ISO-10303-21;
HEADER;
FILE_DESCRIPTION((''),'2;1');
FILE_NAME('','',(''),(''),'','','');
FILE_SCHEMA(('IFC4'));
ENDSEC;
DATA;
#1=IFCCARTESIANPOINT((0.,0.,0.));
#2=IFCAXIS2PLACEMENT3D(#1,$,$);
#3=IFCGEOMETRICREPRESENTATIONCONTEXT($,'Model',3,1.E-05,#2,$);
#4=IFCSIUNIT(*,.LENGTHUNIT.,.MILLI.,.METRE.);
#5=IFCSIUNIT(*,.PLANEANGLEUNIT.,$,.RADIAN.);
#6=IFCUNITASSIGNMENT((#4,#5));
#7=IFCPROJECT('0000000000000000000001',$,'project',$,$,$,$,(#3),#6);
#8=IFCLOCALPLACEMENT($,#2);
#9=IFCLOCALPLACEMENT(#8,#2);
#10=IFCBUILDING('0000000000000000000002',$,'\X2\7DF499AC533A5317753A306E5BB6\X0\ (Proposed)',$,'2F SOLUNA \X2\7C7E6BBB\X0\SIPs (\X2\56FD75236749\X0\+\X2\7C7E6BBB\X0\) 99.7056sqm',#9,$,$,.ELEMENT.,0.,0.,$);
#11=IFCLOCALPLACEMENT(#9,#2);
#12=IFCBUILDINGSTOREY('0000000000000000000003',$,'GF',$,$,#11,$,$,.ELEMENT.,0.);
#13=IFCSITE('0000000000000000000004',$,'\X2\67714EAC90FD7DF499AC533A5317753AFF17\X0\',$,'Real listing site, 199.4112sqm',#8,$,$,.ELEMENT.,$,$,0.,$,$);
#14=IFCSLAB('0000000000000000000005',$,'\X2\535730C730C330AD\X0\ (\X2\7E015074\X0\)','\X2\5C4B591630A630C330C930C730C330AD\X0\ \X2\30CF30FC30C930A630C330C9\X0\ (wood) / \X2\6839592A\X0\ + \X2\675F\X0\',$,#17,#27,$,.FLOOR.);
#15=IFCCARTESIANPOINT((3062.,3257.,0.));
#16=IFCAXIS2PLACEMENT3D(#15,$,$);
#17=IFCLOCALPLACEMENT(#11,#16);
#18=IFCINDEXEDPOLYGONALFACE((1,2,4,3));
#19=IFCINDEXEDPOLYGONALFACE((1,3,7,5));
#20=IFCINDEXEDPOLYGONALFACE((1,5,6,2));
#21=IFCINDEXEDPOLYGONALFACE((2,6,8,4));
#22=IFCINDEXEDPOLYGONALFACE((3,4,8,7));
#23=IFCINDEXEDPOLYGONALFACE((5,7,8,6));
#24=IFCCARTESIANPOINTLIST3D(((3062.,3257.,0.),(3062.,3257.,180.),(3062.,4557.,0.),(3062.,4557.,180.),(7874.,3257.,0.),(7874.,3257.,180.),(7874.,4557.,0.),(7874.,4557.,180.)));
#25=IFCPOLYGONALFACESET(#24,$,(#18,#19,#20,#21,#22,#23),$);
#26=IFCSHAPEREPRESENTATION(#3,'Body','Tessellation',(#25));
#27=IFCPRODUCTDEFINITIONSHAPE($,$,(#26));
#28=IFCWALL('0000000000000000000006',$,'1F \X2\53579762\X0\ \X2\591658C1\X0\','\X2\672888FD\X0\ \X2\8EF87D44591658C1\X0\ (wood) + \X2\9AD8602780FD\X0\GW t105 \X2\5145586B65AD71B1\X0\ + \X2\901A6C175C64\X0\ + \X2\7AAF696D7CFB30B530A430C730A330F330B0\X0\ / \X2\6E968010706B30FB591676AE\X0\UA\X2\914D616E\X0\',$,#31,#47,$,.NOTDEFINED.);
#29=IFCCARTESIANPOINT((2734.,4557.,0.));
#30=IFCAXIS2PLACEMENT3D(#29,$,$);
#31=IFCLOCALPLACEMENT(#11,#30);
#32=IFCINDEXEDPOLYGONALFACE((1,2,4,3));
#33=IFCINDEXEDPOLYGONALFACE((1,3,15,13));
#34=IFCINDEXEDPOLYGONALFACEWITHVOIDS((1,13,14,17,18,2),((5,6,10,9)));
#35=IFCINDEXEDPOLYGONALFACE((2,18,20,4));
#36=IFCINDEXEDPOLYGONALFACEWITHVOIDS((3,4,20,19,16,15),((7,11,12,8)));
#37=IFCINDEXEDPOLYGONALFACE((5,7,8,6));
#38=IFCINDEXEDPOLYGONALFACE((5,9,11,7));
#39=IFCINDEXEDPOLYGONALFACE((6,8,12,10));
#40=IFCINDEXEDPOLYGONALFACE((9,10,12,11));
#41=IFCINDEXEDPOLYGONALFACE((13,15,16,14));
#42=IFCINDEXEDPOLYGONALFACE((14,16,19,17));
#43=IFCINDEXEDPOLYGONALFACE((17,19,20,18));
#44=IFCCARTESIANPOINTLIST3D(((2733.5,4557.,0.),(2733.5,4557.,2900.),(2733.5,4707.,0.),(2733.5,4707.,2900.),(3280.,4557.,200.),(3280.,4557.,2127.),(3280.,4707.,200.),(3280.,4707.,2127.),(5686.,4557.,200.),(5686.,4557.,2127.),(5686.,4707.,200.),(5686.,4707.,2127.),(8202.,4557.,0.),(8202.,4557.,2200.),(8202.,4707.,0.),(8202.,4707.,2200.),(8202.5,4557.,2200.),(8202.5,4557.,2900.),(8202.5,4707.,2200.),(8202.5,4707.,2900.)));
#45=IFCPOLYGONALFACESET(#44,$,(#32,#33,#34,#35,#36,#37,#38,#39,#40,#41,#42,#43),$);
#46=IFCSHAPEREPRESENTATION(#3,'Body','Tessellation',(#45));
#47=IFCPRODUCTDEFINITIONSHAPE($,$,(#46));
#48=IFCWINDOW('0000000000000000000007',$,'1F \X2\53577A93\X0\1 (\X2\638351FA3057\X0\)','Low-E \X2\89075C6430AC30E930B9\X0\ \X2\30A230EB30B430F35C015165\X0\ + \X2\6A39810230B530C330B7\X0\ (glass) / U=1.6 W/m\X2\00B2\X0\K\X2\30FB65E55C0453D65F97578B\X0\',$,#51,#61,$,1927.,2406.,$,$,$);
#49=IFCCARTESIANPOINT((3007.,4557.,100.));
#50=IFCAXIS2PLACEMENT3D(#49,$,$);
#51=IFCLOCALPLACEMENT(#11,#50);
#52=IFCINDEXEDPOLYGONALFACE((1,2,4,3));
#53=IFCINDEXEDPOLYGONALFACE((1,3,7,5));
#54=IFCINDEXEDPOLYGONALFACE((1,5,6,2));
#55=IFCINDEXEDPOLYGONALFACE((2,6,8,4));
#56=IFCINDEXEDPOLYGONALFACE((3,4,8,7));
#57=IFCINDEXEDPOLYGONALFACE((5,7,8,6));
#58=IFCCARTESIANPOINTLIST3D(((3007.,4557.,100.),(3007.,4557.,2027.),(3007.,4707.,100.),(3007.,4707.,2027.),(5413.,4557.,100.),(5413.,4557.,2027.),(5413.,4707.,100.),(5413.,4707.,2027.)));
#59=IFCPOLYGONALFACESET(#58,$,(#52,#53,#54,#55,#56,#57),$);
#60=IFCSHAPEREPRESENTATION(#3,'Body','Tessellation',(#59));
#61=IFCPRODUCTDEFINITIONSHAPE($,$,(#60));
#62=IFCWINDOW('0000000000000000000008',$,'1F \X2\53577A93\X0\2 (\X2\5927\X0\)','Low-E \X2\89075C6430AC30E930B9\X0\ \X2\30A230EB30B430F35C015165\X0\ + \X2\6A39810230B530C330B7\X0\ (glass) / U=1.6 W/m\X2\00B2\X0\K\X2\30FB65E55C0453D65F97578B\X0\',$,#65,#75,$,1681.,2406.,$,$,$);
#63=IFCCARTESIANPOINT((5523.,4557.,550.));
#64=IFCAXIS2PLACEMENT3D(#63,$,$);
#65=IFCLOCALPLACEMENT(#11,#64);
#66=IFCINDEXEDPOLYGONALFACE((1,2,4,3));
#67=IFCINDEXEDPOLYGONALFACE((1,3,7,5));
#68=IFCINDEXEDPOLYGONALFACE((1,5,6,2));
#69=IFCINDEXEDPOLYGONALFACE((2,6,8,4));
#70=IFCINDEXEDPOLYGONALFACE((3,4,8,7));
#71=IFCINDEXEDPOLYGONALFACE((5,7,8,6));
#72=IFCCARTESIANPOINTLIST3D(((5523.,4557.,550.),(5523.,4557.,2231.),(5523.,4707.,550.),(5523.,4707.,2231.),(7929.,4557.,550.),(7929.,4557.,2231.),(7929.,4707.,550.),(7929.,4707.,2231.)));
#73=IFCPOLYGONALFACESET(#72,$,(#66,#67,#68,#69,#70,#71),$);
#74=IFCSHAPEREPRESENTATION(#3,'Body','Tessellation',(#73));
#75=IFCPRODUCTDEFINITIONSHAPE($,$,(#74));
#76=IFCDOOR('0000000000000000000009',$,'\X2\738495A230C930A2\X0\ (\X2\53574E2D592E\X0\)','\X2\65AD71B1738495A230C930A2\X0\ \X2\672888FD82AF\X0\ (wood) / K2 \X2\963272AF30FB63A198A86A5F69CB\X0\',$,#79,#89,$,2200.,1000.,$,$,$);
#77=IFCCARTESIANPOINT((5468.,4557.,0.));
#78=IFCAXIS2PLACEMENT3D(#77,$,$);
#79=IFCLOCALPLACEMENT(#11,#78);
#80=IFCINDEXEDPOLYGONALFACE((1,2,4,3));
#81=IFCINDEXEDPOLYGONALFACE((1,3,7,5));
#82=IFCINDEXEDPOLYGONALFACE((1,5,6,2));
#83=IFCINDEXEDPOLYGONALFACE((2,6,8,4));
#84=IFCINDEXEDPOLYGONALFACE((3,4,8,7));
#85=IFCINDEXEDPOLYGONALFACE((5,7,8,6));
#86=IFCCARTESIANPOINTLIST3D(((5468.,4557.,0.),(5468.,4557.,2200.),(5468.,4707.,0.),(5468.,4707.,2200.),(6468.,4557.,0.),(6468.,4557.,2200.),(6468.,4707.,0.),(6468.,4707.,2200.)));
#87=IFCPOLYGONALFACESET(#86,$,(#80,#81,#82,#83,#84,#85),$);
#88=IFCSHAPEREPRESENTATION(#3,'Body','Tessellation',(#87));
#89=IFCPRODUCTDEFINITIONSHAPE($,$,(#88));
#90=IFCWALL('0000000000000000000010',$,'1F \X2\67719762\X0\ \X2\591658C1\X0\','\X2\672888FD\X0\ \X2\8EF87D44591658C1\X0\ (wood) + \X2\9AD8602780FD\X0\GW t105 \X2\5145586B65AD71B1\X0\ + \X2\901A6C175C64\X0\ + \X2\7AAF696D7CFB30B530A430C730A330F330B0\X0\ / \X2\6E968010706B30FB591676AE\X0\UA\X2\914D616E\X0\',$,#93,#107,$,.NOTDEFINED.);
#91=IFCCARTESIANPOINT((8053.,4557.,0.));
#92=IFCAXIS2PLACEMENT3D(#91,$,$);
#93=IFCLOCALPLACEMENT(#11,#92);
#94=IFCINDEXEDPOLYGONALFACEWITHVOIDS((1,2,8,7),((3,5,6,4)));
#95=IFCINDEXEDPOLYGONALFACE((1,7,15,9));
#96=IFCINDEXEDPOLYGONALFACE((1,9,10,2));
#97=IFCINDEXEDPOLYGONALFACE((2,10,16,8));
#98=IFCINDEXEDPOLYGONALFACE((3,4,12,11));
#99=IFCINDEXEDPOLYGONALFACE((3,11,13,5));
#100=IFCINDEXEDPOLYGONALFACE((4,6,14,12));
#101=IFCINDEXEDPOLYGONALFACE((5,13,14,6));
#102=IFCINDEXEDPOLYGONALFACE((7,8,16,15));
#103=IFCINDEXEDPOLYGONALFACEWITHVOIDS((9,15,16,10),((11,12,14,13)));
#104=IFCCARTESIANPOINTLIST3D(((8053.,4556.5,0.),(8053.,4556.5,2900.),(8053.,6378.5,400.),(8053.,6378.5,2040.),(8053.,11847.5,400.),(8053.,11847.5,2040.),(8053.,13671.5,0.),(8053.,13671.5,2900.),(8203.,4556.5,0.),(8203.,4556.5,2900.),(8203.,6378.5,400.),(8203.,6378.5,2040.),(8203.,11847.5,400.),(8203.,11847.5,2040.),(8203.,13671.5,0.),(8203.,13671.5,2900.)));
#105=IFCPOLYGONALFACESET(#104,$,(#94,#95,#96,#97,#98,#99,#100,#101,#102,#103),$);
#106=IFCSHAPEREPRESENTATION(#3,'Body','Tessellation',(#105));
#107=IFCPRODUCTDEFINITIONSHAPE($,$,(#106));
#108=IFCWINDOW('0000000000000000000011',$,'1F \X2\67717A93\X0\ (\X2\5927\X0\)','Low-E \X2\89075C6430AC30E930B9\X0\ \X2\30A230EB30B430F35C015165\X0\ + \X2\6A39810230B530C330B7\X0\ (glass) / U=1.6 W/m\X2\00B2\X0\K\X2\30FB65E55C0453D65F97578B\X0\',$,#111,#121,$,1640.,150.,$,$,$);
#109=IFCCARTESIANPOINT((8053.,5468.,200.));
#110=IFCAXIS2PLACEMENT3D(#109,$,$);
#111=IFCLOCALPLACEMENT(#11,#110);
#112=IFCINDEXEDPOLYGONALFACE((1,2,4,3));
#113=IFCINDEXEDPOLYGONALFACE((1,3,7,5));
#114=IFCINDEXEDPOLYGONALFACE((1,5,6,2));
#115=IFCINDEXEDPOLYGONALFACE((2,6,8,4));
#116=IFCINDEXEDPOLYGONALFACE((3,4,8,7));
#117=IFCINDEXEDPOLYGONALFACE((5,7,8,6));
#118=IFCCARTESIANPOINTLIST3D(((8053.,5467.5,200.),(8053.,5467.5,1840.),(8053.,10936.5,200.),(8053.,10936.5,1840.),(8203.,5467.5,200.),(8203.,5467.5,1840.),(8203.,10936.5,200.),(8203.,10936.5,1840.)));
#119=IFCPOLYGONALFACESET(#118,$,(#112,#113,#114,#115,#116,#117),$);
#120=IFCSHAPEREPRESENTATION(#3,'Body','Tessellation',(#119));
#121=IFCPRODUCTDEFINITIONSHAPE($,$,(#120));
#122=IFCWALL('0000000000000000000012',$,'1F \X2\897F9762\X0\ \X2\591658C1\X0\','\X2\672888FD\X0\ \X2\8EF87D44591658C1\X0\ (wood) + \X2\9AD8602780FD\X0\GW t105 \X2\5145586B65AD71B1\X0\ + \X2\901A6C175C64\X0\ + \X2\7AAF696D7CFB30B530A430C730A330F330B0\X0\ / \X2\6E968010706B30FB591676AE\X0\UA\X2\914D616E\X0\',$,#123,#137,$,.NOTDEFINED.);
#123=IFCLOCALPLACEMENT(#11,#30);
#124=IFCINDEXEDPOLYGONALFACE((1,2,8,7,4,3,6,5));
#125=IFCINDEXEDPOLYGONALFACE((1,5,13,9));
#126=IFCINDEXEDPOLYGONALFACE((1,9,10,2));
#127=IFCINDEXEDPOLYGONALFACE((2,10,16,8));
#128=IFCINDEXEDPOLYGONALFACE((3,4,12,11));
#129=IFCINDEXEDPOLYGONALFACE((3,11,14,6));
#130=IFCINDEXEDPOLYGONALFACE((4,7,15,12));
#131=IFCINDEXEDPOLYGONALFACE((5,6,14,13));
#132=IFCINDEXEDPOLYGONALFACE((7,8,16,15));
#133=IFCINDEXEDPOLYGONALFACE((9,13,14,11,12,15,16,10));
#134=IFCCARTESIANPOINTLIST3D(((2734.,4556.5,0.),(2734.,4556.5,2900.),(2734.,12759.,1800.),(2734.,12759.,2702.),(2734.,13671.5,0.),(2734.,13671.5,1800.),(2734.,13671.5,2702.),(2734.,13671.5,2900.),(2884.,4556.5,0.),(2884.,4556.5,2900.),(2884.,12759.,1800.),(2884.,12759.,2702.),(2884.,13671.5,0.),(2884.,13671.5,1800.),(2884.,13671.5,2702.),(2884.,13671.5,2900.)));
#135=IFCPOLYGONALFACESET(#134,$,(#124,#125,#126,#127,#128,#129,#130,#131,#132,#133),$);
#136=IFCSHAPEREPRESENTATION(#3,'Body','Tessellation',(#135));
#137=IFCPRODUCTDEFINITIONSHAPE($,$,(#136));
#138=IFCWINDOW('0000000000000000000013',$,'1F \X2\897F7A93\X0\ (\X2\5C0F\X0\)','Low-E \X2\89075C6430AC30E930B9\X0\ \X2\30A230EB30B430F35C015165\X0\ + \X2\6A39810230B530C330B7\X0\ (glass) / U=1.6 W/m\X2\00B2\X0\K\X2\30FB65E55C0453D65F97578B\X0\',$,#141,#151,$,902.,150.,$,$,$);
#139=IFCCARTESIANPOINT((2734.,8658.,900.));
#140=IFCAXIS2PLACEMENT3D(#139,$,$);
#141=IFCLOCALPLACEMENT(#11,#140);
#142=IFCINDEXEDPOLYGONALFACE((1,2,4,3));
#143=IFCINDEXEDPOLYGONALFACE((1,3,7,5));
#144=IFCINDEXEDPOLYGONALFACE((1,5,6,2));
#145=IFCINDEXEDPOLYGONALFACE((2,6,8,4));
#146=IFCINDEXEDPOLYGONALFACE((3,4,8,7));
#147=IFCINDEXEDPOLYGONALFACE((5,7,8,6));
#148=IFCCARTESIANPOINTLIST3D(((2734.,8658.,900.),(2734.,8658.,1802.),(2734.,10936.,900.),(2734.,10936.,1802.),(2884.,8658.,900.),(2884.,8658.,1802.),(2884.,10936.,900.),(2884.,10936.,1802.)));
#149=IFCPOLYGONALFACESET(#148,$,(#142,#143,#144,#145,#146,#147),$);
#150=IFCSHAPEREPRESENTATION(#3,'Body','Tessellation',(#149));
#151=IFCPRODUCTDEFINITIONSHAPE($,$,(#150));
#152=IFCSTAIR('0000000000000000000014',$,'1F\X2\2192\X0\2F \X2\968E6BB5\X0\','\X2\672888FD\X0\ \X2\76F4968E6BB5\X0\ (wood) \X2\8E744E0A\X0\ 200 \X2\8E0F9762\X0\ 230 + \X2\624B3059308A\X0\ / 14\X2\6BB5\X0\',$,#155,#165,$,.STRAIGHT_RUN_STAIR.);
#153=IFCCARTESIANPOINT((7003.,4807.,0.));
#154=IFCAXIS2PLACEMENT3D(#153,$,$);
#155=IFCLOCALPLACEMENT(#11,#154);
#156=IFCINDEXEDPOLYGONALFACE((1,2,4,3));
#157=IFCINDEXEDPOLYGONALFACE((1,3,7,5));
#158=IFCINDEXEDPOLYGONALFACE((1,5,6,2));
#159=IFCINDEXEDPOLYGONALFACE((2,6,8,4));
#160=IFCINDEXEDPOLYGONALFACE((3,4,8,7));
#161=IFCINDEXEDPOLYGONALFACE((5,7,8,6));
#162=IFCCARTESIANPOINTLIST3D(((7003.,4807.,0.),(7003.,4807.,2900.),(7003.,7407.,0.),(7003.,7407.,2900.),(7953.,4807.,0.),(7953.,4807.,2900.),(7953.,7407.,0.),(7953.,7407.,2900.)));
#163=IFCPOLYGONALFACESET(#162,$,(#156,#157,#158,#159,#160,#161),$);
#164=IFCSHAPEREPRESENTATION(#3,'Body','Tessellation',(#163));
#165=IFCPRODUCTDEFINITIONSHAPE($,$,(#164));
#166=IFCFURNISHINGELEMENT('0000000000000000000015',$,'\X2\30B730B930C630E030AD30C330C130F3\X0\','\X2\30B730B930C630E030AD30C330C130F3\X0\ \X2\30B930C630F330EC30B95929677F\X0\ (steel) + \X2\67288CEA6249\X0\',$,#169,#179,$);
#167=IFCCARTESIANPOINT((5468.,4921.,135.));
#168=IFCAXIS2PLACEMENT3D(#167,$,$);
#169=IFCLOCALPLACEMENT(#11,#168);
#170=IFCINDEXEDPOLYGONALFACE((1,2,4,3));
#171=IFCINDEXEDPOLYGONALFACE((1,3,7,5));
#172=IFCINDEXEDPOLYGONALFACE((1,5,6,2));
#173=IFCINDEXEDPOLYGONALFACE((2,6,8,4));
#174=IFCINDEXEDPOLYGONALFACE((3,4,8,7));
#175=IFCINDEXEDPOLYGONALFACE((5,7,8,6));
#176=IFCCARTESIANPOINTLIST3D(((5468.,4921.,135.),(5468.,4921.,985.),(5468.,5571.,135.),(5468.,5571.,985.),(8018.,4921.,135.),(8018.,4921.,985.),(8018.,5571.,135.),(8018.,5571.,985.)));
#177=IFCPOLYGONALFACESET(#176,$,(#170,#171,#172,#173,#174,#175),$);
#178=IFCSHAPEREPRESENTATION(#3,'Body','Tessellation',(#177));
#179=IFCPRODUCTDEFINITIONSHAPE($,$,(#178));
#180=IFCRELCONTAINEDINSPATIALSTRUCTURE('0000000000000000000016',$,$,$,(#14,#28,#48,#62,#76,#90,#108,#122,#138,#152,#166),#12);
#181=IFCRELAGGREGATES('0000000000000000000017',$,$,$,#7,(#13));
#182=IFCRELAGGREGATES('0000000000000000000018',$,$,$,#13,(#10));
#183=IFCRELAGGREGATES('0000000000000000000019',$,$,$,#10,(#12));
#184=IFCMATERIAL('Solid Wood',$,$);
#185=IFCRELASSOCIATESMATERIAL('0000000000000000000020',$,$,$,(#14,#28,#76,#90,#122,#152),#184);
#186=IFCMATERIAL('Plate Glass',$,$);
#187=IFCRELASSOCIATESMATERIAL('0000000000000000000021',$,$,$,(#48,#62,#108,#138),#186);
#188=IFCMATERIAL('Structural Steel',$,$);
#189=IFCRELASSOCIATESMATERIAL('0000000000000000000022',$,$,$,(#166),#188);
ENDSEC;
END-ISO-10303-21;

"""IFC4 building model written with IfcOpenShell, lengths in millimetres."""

from ifc_helpers import new_model, si_unit, frame, frame_2d, origin, place, context, project, spatial, rectangle, extrude, material, element, fill, save


model = new_model("IFC4")

# Units and contexts
model_context = context("Model", 3, precision=1e-05, world=origin())
ifc_project = project(units=[si_unit("LENGTHUNIT", "METRE", prefix="MILLI"), si_unit("PLANEANGLEUNIT", "RADIAN")], contexts=[model_context])

# Site, building, storey
site_placement = place(None, origin())
site = spatial("IfcSite", under=ifc_project, at=site_placement, Name="東京都練馬区北町７", ObjectType="Real listing site, 199.4112sqm", CompositionType="ELEMENT", RefElevation=0.0)
building_placement = place(site_placement, origin())
building = spatial("IfcBuilding", under=site, at=building_placement, Name="練馬区北町の家 (Proposed)", ObjectType="2F SOLUNA 籾殻SIPs (国産杉+籾殻) 99.7056sqm", CompositionType="ELEMENT", ElevationOfRefHeight=0.0, ElevationOfTerrain=0.0)
storey_placement = place(building_placement, origin())
storey = spatial("IfcBuildingStorey", under=building, at=storey_placement, Name="GF", CompositionType="ELEMENT", Elevation=0.0)

# Slab
ifc_material_1 = material(Name="Solid Wood")
slab_1_placement = place(storey_placement, frame((3062.0, 3257.0, 0.0)))
element("IfcSlab", 1, at=slab_1_placement, inside=storey, material=ifc_material_1, Name="南デッキ (縁側)", Description="屋外ウッドデッキ ハードウッド (wood) / 根太 + 束", PredefinedType="FLOOR", context=model_context, shape_type="SweptSolid", body=[
    extrude(rectangle(XDim=4812.0, YDim=1300.0, at=frame_2d((2406.0, 650.0))), frame((3062.0, 3257.0, 0.0)), (0.0, 0.0, 1.0), 180.0),
])

# Wall, openings, windows, door
wall_1_placement = place(storey_placement, frame((2734.0, 4557.0, 0.0)))
wall_1 = element("IfcWall", 2, at=wall_1_placement, inside=storey, material=ifc_material_1, Name="1F 南面 外壁", Description="木製 軸組外壁 (wood) + 高性能GW t105 充填断熱 + 通気層 + 窯業系サイディング / 準耐火・外皮UA配慮", PredefinedType="NOTDEFINED", context=model_context, shape_type="SweptSolid", body=[
    extrude(rectangle(XDim=5469.0, YDim=150.0, at=frame_2d((2734.0, 75.0))), frame((2734.0, 4557.0, 0.0)), (0.0, 0.0, 1.0), 2900.0),
])
opening_1_placement = place(storey_placement, frame((3007.0, 4557.0, 100.0)))
opening_1 = element("IfcOpeningElement", 3, at=opening_1_placement, cuts=wall_1, PredefinedType="NOTDEFINED", context=model_context, shape_type="SweptSolid", body=[
    extrude(rectangle(XDim=2406.0, YDim=150.0, at=frame_2d((1203.0, 75.0))), frame((3007.0, 4557.0, 100.0)), (0.0, 0.0, 1.0), 1927.0),
])
opening_2_placement = place(storey_placement, frame((5523.0, 4557.0, 550.0)))
opening_2 = element("IfcOpeningElement", 4, at=opening_2_placement, cuts=wall_1, PredefinedType="NOTDEFINED", context=model_context, shape_type="SweptSolid", body=[
    extrude(rectangle(XDim=2406.0, YDim=150.0, at=frame_2d((1203.0, 75.0))), frame((5523.0, 4557.0, 550.0)), (0.0, 0.0, 1.0), 1681.0),
])
opening_3_placement = place(storey_placement, frame((5468.0, 4557.0, 0.0)))
opening_3 = element("IfcOpeningElement", 5, at=opening_3_placement, cuts=wall_1, PredefinedType="NOTDEFINED", context=model_context, shape_type="SweptSolid", body=[
    extrude(rectangle(XDim=1000.0, YDim=150.0, at=frame_2d((500.0, 75.0))), frame((5468.0, 4557.0, 0.0)), (0.0, 0.0, 1.0), 2200.0),
])
ifc_material_2 = material(Name="Plate Glass")
window_1_placement = place(storey_placement, frame((3007.0, 4557.0, 100.0)))
window_1 = element("IfcWindow", 6, at=window_1_placement, inside=storey, material=ifc_material_2, Name="1F 南窓1 (掃出し)", Description="Low-E 複層ガラス アルゴン封入 + 樹脂サッシ (glass) / U=1.6 W/m²K・日射取得型", OverallHeight=1927.0, OverallWidth=2406.0, context=model_context, shape_type="SweptSolid", body=[
    extrude(rectangle(XDim=2406.0, YDim=150.0, at=frame_2d((1203.0, 75.0))), frame((3007.0, 4557.0, 100.0)), (0.0, 0.0, 1.0), 1927.0),
])
fill(opening_1, window_1)
window_2_placement = place(storey_placement, frame((5523.0, 4557.0, 550.0)))
window_2 = element("IfcWindow", 7, at=window_2_placement, inside=storey, material=ifc_material_2, Name="1F 南窓2 (大)", Description="Low-E 複層ガラス アルゴン封入 + 樹脂サッシ (glass) / U=1.6 W/m²K・日射取得型", OverallHeight=1681.0, OverallWidth=2406.0, context=model_context, shape_type="SweptSolid", body=[
    extrude(rectangle(XDim=2406.0, YDim=150.0, at=frame_2d((1203.0, 75.0))), frame((5523.0, 4557.0, 550.0)), (0.0, 0.0, 1.0), 1681.0),
])
fill(opening_2, window_2)
door_placement = place(storey_placement, frame((5468.0, 4557.0, 0.0)))
door = element("IfcDoor", 8, at=door_placement, inside=storey, material=ifc_material_1, Name="玄関ドア (南中央)", Description="断熱玄関ドア 木製芯 (wood) / K2 防犯・採風機構", OverallHeight=2200.0, OverallWidth=1000.0, context=model_context, shape_type="SweptSolid", body=[
    extrude(rectangle(XDim=1000.0, YDim=150.0, at=frame_2d((500.0, 75.0))), frame((5468.0, 4557.0, 0.0)), (0.0, 0.0, 1.0), 2200.0),
])
fill(opening_3, door)

# Walls, openings, windows
wall_2_placement = place(storey_placement, frame((8053.0, 4557.0, 0.0)))
wall_2 = element("IfcWall", 9, at=wall_2_placement, inside=storey, material=ifc_material_1, Name="1F 東面 外壁", Description="木製 軸組外壁 (wood) + 高性能GW t105 充填断熱 + 通気層 + 窯業系サイディング / 準耐火・外皮UA配慮", PredefinedType="NOTDEFINED", context=model_context, shape_type="SweptSolid", body=[
    extrude(rectangle(XDim=150.0, YDim=9115.0, at=frame_2d((75.0, 4557.0))), frame((8053.0, 4557.0, 0.0)), (0.0, 0.0, 1.0), 2900.0),
])
opening_4_placement = place(storey_placement, frame((8053.0, 5468.0, 200.0)))
opening_4 = element("IfcOpeningElement", 10, at=opening_4_placement, cuts=wall_2, PredefinedType="NOTDEFINED", context=model_context, shape_type="SweptSolid", body=[
    extrude(rectangle(XDim=150.0, YDim=5469.0, at=frame_2d((75.0, 2734.0))), frame((8053.0, 5468.0, 200.0)), (0.0, 0.0, 1.0), 1640.0),
])
window_3_placement = place(storey_placement, frame((8053.0, 5468.0, 200.0)))
window_3 = element("IfcWindow", 11, at=window_3_placement, inside=storey, material=ifc_material_2, Name="1F 東窓 (大)", Description="Low-E 複層ガラス アルゴン封入 + 樹脂サッシ (glass) / U=1.6 W/m²K・日射取得型", OverallHeight=1640.0, OverallWidth=150.0, context=model_context, shape_type="SweptSolid", body=[
    extrude(rectangle(XDim=150.0, YDim=5469.0, at=frame_2d((75.0, 2734.0))), frame((8053.0, 5468.0, 200.0)), (0.0, 0.0, 1.0), 1640.0),
])
fill(opening_4, window_3)
wall_3_placement = place(storey_placement, frame((2734.0, 4557.0, 0.0)))
wall_3 = element("IfcWall", 12, at=wall_3_placement, inside=storey, material=ifc_material_1, Name="1F 西面 外壁", Description="木製 軸組外壁 (wood) + 高性能GW t105 充填断熱 + 通気層 + 窯業系サイディング / 準耐火・外皮UA配慮", PredefinedType="NOTDEFINED", context=model_context, shape_type="SweptSolid", body=[
    extrude(rectangle(XDim=150.0, YDim=9115.0, at=frame_2d((75.0, 4557.0))), frame((2734.0, 4557.0, 0.0)), (0.0, 0.0, 1.0), 2900.0),
])
opening_5_placement = place(storey_placement, frame((2734.0, 8658.0, 900.0)))
opening_5 = element("IfcOpeningElement", 13, at=opening_5_placement, cuts=wall_3, PredefinedType="NOTDEFINED", context=model_context, shape_type="SweptSolid", body=[
    extrude(rectangle(XDim=150.0, YDim=2278.0, at=frame_2d((75.0, 1139.0))), frame((2734.0, 8658.0, 900.0)), (0.0, 0.0, 1.0), 902.0),
])
window_4_placement = place(storey_placement, frame((2734.0, 8658.0, 900.0)))
window_4 = element("IfcWindow", 14, at=window_4_placement, inside=storey, material=ifc_material_2, Name="1F 西窓 (小)", Description="Low-E 複層ガラス アルゴン封入 + 樹脂サッシ (glass) / U=1.6 W/m²K・日射取得型", OverallHeight=902.0, OverallWidth=150.0, context=model_context, shape_type="SweptSolid", body=[
    extrude(rectangle(XDim=150.0, YDim=2278.0, at=frame_2d((75.0, 1139.0))), frame((2734.0, 8658.0, 900.0)), (0.0, 0.0, 1.0), 902.0),
])
fill(opening_5, window_4)

# Stair
stair_placement = place(storey_placement, frame((7003.0, 4807.0, 0.0)))
element("IfcStair", 15, at=stair_placement, inside=storey, material=ifc_material_1, Name="1F→2F 階段", Description="木製 直階段 (wood) 蹴上 200 踏面 230 + 手すり / 14段", PredefinedType="STRAIGHT_RUN_STAIR", context=model_context, shape_type="SweptSolid", body=[
    extrude(rectangle(XDim=950.0, YDim=2600.0, at=frame_2d((475.0, 1300.0))), frame((7003.0, 4807.0, 0.0)), (0.0, 0.0, 1.0), 2900.0),
])

# Furnishing element
ifc_material_3 = material(Name="Structural Steel")
furnishing_placement = place(storey_placement, frame((5468.0, 4921.0, 135.0)))
element("IfcFurnishingElement", 16, at=furnishing_placement, inside=storey, material=ifc_material_3, Name="システムキッチン", Description="システムキッチン ステンレス天板 (steel) + 木質扉", context=model_context, shape_type="SweptSolid", body=[
    extrude(rectangle(XDim=2550.0, YDim=650.0, at=frame_2d((1275.0, 325.0))), frame((5468.0, 4921.0, 135.0)), (0.0, 0.0, 1.0), 850.0),
])

save(model, "model.ifc")
